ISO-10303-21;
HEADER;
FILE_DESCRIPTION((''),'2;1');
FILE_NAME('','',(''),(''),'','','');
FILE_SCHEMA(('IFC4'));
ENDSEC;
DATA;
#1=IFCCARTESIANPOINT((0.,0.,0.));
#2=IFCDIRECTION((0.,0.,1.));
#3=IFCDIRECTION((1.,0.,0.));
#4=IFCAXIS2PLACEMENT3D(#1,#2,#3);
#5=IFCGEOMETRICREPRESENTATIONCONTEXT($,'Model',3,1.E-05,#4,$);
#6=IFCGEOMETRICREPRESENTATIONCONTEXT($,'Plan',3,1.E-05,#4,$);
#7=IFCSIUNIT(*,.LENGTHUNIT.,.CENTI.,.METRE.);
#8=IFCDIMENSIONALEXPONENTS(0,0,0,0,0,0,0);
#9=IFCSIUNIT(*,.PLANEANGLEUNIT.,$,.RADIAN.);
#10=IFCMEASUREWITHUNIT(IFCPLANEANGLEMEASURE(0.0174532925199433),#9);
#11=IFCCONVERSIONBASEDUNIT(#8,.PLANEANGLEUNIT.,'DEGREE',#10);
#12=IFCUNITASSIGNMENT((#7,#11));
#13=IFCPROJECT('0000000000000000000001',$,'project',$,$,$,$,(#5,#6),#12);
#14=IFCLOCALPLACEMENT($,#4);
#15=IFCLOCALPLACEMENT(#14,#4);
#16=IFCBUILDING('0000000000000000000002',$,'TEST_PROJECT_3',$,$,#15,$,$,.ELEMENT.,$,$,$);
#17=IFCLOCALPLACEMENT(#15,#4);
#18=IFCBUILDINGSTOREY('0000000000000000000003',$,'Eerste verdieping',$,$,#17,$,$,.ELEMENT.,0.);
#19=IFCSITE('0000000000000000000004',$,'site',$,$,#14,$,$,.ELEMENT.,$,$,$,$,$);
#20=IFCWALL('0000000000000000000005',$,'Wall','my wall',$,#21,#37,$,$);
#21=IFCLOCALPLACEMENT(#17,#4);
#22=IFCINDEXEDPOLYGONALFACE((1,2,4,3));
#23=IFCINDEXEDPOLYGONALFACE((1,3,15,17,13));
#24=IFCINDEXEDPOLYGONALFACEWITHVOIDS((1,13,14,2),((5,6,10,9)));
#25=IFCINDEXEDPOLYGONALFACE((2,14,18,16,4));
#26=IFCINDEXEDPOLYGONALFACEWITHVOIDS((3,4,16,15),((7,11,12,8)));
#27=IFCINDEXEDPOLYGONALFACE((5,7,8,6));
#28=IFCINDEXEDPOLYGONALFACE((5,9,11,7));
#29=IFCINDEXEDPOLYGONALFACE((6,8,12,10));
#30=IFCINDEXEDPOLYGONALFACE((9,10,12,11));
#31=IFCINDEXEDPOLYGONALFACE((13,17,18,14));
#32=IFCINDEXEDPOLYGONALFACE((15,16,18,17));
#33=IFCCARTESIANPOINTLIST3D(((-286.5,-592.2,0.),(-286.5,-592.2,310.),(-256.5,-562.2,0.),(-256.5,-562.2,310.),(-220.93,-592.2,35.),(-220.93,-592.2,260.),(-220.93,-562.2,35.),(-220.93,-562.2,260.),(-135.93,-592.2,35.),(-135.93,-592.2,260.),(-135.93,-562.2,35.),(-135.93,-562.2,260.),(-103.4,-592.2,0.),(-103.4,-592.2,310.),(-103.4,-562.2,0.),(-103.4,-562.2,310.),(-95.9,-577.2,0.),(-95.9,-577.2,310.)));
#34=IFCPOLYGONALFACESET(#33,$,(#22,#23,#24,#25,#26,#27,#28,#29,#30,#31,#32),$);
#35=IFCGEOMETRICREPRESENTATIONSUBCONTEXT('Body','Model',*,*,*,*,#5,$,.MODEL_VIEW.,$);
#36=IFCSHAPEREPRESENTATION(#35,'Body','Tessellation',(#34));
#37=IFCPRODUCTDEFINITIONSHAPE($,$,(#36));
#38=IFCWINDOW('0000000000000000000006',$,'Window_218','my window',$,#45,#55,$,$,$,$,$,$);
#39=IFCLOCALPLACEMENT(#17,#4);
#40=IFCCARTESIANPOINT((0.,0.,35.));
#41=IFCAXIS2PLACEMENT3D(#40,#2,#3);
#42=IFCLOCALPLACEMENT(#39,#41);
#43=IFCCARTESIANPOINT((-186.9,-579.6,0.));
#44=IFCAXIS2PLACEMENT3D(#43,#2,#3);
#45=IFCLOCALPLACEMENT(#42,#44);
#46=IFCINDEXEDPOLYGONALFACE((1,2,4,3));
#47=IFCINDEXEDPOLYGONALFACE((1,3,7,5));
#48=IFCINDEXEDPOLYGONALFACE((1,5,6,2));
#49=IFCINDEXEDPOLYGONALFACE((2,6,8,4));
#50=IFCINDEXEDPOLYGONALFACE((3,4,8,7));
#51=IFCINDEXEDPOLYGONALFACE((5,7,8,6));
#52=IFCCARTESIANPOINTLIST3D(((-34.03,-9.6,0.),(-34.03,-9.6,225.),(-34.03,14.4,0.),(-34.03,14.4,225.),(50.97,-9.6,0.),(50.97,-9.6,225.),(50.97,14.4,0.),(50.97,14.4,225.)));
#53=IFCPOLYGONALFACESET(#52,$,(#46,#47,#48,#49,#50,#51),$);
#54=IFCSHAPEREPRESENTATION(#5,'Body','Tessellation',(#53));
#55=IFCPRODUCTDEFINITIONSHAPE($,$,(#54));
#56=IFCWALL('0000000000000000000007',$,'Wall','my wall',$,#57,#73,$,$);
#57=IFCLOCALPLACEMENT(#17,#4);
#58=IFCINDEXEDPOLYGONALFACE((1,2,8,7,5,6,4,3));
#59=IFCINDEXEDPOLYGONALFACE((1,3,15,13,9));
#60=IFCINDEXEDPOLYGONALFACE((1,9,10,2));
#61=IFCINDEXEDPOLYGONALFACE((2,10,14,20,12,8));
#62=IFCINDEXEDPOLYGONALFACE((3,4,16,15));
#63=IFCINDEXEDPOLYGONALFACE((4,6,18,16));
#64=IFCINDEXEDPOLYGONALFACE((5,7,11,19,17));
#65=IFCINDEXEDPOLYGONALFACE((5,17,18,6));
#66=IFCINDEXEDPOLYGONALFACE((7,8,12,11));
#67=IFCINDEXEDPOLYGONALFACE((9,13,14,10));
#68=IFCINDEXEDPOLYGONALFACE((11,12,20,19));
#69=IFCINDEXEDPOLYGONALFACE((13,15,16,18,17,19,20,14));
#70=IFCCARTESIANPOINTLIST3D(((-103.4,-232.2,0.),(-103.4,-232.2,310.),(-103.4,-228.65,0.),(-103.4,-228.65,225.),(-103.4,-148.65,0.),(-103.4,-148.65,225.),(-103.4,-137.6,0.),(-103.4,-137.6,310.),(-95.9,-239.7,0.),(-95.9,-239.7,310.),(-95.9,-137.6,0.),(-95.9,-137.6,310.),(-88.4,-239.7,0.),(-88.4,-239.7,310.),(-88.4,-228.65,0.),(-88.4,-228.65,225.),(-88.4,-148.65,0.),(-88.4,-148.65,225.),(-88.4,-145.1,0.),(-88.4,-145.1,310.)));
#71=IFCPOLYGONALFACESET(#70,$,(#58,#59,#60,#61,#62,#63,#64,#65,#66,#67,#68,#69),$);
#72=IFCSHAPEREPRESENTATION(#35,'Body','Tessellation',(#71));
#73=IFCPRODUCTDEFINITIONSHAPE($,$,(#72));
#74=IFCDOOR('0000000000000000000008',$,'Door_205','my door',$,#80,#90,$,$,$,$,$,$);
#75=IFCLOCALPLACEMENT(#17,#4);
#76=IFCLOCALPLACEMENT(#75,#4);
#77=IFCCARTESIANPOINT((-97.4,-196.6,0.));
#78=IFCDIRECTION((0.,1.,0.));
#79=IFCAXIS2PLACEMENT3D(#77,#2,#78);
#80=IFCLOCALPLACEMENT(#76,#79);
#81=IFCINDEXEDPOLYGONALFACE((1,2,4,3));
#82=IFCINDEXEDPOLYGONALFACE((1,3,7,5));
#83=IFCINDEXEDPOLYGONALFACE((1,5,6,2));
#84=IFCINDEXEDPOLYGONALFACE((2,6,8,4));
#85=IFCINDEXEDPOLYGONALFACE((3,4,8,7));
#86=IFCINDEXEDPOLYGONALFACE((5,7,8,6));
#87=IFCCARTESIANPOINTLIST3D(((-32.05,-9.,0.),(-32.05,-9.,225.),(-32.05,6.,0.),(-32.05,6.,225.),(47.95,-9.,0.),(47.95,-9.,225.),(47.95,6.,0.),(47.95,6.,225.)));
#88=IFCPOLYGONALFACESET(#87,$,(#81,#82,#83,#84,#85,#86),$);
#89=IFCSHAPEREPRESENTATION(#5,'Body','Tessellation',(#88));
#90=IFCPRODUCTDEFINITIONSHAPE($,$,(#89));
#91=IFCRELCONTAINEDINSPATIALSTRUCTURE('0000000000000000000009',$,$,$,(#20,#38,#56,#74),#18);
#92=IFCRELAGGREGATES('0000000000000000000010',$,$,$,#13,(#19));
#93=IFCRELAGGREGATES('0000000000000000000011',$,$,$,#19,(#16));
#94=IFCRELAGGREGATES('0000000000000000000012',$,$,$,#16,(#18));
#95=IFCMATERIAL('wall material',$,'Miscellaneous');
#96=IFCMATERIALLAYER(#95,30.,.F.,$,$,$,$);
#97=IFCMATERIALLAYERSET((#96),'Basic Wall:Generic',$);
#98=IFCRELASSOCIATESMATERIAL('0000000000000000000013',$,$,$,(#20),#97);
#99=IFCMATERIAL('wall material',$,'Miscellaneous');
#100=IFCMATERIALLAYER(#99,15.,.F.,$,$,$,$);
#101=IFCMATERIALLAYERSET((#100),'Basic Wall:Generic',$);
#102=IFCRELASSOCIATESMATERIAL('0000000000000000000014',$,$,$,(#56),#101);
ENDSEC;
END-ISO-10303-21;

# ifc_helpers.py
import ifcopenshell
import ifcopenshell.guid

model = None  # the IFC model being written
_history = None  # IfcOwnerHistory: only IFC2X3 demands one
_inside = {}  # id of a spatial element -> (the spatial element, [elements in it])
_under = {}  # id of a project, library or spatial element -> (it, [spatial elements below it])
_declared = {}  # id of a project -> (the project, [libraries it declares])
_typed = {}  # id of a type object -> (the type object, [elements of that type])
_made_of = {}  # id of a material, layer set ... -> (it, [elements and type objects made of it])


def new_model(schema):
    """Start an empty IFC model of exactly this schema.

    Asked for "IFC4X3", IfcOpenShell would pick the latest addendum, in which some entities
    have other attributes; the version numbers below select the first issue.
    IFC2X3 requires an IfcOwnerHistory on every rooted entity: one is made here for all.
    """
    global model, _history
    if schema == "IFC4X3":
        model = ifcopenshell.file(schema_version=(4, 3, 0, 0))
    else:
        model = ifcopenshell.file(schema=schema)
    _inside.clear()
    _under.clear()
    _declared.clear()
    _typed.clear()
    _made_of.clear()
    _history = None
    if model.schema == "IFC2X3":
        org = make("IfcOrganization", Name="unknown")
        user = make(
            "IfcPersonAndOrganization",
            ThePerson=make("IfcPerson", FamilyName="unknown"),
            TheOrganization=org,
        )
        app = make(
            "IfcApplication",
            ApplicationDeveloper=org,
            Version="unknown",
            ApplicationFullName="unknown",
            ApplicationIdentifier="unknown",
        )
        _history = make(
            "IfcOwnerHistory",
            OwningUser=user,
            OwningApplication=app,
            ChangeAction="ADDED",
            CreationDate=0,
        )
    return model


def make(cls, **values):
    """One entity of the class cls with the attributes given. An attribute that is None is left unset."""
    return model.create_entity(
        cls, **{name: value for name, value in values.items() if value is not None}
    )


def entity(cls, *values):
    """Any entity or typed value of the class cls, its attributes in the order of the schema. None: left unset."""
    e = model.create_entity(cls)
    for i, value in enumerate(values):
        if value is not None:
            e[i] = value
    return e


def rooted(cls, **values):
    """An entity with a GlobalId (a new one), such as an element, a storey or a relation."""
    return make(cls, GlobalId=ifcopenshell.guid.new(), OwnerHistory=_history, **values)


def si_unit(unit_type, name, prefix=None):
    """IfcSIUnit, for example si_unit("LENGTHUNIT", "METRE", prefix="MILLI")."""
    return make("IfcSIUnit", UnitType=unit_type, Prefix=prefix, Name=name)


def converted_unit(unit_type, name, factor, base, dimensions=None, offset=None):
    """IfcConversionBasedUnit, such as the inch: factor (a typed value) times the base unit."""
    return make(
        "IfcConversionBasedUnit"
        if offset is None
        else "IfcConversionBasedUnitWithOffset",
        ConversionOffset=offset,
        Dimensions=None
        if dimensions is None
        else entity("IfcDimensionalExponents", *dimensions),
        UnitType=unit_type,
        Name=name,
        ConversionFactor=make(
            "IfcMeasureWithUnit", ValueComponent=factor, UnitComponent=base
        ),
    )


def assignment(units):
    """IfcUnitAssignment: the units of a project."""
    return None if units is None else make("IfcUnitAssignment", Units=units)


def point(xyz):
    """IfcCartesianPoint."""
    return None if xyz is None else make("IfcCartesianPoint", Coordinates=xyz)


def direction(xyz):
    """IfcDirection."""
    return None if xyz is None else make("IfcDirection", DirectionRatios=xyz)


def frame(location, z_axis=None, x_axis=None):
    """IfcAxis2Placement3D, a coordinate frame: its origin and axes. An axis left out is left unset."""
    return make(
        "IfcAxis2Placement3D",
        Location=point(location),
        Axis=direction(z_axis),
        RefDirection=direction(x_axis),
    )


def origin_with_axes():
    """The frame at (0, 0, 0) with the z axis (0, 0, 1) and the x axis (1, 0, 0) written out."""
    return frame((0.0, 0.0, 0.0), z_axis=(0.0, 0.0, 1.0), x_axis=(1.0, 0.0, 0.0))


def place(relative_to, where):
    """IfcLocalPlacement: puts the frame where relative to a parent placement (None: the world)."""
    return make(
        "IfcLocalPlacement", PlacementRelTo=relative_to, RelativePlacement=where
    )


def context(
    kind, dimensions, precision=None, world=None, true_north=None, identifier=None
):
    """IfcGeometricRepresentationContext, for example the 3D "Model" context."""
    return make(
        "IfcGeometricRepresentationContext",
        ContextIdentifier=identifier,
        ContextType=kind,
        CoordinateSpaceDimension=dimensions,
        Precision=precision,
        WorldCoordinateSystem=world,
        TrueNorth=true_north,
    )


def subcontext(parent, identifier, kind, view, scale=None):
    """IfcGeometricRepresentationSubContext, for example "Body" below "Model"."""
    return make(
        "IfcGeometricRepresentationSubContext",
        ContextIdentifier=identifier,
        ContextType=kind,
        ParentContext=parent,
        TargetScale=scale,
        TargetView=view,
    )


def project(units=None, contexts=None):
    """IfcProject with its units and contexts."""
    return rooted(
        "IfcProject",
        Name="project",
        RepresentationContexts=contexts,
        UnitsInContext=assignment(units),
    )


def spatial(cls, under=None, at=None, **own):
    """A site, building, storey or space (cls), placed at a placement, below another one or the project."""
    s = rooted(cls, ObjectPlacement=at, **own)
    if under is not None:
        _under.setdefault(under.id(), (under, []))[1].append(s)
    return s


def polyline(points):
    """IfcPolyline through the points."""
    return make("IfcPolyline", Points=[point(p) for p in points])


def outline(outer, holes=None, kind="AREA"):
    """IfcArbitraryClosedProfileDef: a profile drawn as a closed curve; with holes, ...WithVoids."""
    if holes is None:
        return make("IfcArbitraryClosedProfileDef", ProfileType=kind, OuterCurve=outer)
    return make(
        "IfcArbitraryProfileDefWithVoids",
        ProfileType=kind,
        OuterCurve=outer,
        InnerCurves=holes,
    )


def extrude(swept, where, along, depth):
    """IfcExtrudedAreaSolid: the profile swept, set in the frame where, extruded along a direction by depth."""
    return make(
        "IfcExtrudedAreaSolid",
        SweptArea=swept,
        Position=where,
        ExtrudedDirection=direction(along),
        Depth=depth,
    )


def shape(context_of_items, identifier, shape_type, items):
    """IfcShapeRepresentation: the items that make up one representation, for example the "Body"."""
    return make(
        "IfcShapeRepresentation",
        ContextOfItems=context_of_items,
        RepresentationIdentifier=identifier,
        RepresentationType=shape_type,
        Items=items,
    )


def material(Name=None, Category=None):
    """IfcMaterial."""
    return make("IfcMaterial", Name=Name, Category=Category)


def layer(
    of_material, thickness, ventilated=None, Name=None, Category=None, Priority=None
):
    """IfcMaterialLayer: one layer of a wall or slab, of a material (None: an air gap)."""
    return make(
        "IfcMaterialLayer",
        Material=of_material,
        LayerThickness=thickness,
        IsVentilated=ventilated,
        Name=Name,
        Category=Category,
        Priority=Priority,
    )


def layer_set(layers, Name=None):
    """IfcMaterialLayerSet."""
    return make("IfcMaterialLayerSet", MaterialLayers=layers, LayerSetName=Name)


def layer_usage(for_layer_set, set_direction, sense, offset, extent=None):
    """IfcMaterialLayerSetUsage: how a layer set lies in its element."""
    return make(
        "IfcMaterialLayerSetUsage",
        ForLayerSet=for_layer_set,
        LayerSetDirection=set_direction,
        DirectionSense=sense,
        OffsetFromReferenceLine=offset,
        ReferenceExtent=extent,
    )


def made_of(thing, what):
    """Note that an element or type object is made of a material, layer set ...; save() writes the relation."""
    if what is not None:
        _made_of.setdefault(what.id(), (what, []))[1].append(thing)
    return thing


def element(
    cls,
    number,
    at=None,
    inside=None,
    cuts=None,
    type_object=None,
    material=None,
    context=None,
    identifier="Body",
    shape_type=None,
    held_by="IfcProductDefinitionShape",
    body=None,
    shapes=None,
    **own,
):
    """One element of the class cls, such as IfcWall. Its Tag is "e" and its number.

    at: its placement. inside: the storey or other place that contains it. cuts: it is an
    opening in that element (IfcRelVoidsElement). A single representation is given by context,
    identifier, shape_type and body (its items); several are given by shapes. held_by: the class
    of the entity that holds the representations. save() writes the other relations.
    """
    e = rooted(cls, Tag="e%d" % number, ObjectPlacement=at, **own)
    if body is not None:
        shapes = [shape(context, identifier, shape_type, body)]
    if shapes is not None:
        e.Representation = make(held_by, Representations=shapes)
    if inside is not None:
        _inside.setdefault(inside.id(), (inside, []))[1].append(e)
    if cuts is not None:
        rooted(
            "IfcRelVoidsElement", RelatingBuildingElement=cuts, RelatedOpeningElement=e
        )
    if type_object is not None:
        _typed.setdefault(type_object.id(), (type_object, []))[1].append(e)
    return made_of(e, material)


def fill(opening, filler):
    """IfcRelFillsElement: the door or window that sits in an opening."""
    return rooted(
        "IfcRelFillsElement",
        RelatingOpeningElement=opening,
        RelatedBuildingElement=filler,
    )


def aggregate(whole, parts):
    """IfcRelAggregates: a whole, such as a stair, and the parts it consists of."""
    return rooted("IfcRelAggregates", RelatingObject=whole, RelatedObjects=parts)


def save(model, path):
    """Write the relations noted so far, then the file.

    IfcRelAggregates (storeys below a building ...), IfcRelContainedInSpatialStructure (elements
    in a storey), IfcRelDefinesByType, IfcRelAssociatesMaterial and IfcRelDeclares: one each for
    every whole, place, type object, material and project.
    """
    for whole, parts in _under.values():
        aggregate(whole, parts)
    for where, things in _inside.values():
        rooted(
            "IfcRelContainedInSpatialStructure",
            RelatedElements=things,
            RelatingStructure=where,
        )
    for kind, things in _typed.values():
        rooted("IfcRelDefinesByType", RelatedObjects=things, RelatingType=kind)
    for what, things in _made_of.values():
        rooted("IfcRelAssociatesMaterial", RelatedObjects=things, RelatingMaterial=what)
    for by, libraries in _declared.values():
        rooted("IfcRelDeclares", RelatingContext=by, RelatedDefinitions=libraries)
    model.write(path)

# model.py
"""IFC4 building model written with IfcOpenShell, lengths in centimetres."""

from ifc_helpers import new_model, entity, si_unit, converted_unit, frame, origin_with_axes, place, context, subcontext, project, spatial, polyline, outline, extrude, material, layer, layer_set, layer_usage, element, fill, save


model = new_model("IFC4")

# Units and contexts
model_context = context("Model", 3, precision=1e-05, world=origin_with_axes())
plan_context = context("Plan", 3, precision=1e-05, world=origin_with_axes())
body_context = subcontext(model_context, "Body", "Model", "MODEL_VIEW")
ifc_project = project(units=[si_unit("LENGTHUNIT", "METRE", prefix="CENTI"), converted_unit("PLANEANGLEUNIT", "DEGREE", entity("IfcPlaneAngleMeasure", 0.0174532925199433), si_unit("PLANEANGLEUNIT", "RADIAN"), dimensions=[0, 0, 0, 0, 0, 0, 0])], contexts=[model_context, plan_context])

# Site, building, storey
site_placement = place(None, origin_with_axes())
site = spatial("IfcSite", under=ifc_project, at=site_placement, Name="site", CompositionType="ELEMENT")
building_placement = place(site_placement, origin_with_axes())
building = spatial("IfcBuilding", under=site, at=building_placement, Name="TEST_PROJECT_3", CompositionType="ELEMENT")
storey_placement = place(building_placement, origin_with_axes())
storey = spatial("IfcBuildingStorey", under=building, at=storey_placement, Name="Eerste verdieping", CompositionType="ELEMENT", Elevation=0.0)

# Wall, opening, window
ifc_material_1 = material(Name="wall material", Category="Miscellaneous")
ifc_layer_1 = layer(ifc_material_1, 30.0, ventilated=False)
ifc_layer_set_1 = layer_set([ifc_layer_1], Name="Basic Wall:Generic")
ifc_layer_usage_1 = layer_usage(ifc_layer_set_1, "AXIS3", "NEGATIVE", 0.0)
wall_1_placement = place(storey_placement, origin_with_axes())
wall_1 = element("IfcWall", 1, at=wall_1_placement, inside=storey, material=ifc_layer_usage_1, Name="Wall", Description="my wall", context=body_context, shape_type="SweptSolid", body=[
    extrude(outline(polyline([(-286.5, -592.2, 0.0), (-256.5, -562.2, 0.0), (-103.4, -562.2, 0.0), (-95.9, -577.2, 0.0), (-103.4, -592.2, 0.0), (-286.5, -592.2, 0.0)])), origin_with_axes(), (0.0, 0.0, 1.0), 310.0),
])
placement_1 = place(storey_placement, origin_with_axes())
opening_1_placement = place(placement_1, frame((0.0, 0.0, 35.0), z_axis=(0.0, 0.0, 1.0), x_axis=(1.0, 0.0, 0.0)))
opening_1 = element("IfcOpeningElement", 2, at=opening_1_placement, cuts=wall_1, context=model_context, shape_type="SweptSolid", body=[
    extrude(outline(polyline([(-220.93, -592.2, 0.0), (-220.93, -562.2, 0.0), (-135.93, -562.2, 0.0), (-135.93, -592.2, 0.0), (-220.93, -592.2, 0.0)])), origin_with_axes(), (0.0, 0.0, 1.0), 225.0),
])
window_1_placement = place(opening_1_placement, frame((-186.9, -579.6, 0.0), z_axis=(0.0, 0.0, 1.0), x_axis=(1.0, 0.0, 0.0)))
window_1 = element("IfcWindow", 3, at=window_1_placement, inside=storey, Name="Window_218", Description="my window", context=model_context, shape_type="SweptSolid", body=[
    extrude(outline(polyline([(-34.03, -9.6), (-34.03, 14.4), (50.97, 14.4), (50.97, -9.6), (-34.03, -9.6)])), origin_with_axes(), (0.0, 0.0, 1.0), 225.0),
])
fill(opening_1, window_1)

# Wall, opening, door
ifc_material_2 = material(Name="wall material", Category="Miscellaneous")
ifc_layer_2 = layer(ifc_material_2, 15.0, ventilated=False)
ifc_layer_set_2 = layer_set([ifc_layer_2], Name="Basic Wall:Generic")
ifc_layer_usage_2 = layer_usage(ifc_layer_set_2, "AXIS3", "NEGATIVE", 0.0)
wall_2_placement = place(storey_placement, origin_with_axes())
wall_2 = element("IfcWall", 4, at=wall_2_placement, inside=storey, material=ifc_layer_usage_2, Name="Wall", Description="my wall", context=body_context, shape_type="SweptSolid", body=[
    extrude(outline(polyline([(-95.9, -239.7, 0.0), (-103.4, -232.2, 0.0), (-103.4, -137.6, 0.0), (-95.9, -137.6, 0.0), (-88.4, -145.1, 0.0), (-88.4, -239.7, 0.0), (-95.9, -239.7, 0.0)])), origin_with_axes(), (0.0, 0.0, 1.0), 310.0),
])
placement_2 = place(storey_placement, origin_with_axes())
opening_2_placement = place(placement_2, origin_with_axes())
opening_2 = element("IfcOpeningElement", 5, at=opening_2_placement, cuts=wall_2, context=model_context, shape_type="SweptSolid", body=[
    extrude(outline(polyline([(-103.4, -228.65, 0.0), (-103.4, -148.65, 0.0), (-88.4, -148.65, 0.0), (-88.4, -228.65, 0.0), (-103.4, -228.65, 0.0)])), origin_with_axes(), (0.0, 0.0, 1.0), 225.0),
])
door_1_placement = place(opening_2_placement, frame((-97.4, -196.6, 0.0), z_axis=(0.0, 0.0, 1.0), x_axis=(0.0, 1.0, 0.0)))
door_1 = element("IfcDoor", 6, at=door_1_placement, inside=storey, Name="Door_205", Description="my door", context=model_context, shape_type="SweptSolid", body=[
    extrude(outline(polyline([(-32.05, 6.0), (47.95, 6.0), (47.95, -9.0), (-32.05, -9.0), (-32.05, 6.0)])), origin_with_axes(), (0.0, 0.0, 1.0), 225.0),
])
fill(opening_2, door_1)

save(model, "model.ifc")
